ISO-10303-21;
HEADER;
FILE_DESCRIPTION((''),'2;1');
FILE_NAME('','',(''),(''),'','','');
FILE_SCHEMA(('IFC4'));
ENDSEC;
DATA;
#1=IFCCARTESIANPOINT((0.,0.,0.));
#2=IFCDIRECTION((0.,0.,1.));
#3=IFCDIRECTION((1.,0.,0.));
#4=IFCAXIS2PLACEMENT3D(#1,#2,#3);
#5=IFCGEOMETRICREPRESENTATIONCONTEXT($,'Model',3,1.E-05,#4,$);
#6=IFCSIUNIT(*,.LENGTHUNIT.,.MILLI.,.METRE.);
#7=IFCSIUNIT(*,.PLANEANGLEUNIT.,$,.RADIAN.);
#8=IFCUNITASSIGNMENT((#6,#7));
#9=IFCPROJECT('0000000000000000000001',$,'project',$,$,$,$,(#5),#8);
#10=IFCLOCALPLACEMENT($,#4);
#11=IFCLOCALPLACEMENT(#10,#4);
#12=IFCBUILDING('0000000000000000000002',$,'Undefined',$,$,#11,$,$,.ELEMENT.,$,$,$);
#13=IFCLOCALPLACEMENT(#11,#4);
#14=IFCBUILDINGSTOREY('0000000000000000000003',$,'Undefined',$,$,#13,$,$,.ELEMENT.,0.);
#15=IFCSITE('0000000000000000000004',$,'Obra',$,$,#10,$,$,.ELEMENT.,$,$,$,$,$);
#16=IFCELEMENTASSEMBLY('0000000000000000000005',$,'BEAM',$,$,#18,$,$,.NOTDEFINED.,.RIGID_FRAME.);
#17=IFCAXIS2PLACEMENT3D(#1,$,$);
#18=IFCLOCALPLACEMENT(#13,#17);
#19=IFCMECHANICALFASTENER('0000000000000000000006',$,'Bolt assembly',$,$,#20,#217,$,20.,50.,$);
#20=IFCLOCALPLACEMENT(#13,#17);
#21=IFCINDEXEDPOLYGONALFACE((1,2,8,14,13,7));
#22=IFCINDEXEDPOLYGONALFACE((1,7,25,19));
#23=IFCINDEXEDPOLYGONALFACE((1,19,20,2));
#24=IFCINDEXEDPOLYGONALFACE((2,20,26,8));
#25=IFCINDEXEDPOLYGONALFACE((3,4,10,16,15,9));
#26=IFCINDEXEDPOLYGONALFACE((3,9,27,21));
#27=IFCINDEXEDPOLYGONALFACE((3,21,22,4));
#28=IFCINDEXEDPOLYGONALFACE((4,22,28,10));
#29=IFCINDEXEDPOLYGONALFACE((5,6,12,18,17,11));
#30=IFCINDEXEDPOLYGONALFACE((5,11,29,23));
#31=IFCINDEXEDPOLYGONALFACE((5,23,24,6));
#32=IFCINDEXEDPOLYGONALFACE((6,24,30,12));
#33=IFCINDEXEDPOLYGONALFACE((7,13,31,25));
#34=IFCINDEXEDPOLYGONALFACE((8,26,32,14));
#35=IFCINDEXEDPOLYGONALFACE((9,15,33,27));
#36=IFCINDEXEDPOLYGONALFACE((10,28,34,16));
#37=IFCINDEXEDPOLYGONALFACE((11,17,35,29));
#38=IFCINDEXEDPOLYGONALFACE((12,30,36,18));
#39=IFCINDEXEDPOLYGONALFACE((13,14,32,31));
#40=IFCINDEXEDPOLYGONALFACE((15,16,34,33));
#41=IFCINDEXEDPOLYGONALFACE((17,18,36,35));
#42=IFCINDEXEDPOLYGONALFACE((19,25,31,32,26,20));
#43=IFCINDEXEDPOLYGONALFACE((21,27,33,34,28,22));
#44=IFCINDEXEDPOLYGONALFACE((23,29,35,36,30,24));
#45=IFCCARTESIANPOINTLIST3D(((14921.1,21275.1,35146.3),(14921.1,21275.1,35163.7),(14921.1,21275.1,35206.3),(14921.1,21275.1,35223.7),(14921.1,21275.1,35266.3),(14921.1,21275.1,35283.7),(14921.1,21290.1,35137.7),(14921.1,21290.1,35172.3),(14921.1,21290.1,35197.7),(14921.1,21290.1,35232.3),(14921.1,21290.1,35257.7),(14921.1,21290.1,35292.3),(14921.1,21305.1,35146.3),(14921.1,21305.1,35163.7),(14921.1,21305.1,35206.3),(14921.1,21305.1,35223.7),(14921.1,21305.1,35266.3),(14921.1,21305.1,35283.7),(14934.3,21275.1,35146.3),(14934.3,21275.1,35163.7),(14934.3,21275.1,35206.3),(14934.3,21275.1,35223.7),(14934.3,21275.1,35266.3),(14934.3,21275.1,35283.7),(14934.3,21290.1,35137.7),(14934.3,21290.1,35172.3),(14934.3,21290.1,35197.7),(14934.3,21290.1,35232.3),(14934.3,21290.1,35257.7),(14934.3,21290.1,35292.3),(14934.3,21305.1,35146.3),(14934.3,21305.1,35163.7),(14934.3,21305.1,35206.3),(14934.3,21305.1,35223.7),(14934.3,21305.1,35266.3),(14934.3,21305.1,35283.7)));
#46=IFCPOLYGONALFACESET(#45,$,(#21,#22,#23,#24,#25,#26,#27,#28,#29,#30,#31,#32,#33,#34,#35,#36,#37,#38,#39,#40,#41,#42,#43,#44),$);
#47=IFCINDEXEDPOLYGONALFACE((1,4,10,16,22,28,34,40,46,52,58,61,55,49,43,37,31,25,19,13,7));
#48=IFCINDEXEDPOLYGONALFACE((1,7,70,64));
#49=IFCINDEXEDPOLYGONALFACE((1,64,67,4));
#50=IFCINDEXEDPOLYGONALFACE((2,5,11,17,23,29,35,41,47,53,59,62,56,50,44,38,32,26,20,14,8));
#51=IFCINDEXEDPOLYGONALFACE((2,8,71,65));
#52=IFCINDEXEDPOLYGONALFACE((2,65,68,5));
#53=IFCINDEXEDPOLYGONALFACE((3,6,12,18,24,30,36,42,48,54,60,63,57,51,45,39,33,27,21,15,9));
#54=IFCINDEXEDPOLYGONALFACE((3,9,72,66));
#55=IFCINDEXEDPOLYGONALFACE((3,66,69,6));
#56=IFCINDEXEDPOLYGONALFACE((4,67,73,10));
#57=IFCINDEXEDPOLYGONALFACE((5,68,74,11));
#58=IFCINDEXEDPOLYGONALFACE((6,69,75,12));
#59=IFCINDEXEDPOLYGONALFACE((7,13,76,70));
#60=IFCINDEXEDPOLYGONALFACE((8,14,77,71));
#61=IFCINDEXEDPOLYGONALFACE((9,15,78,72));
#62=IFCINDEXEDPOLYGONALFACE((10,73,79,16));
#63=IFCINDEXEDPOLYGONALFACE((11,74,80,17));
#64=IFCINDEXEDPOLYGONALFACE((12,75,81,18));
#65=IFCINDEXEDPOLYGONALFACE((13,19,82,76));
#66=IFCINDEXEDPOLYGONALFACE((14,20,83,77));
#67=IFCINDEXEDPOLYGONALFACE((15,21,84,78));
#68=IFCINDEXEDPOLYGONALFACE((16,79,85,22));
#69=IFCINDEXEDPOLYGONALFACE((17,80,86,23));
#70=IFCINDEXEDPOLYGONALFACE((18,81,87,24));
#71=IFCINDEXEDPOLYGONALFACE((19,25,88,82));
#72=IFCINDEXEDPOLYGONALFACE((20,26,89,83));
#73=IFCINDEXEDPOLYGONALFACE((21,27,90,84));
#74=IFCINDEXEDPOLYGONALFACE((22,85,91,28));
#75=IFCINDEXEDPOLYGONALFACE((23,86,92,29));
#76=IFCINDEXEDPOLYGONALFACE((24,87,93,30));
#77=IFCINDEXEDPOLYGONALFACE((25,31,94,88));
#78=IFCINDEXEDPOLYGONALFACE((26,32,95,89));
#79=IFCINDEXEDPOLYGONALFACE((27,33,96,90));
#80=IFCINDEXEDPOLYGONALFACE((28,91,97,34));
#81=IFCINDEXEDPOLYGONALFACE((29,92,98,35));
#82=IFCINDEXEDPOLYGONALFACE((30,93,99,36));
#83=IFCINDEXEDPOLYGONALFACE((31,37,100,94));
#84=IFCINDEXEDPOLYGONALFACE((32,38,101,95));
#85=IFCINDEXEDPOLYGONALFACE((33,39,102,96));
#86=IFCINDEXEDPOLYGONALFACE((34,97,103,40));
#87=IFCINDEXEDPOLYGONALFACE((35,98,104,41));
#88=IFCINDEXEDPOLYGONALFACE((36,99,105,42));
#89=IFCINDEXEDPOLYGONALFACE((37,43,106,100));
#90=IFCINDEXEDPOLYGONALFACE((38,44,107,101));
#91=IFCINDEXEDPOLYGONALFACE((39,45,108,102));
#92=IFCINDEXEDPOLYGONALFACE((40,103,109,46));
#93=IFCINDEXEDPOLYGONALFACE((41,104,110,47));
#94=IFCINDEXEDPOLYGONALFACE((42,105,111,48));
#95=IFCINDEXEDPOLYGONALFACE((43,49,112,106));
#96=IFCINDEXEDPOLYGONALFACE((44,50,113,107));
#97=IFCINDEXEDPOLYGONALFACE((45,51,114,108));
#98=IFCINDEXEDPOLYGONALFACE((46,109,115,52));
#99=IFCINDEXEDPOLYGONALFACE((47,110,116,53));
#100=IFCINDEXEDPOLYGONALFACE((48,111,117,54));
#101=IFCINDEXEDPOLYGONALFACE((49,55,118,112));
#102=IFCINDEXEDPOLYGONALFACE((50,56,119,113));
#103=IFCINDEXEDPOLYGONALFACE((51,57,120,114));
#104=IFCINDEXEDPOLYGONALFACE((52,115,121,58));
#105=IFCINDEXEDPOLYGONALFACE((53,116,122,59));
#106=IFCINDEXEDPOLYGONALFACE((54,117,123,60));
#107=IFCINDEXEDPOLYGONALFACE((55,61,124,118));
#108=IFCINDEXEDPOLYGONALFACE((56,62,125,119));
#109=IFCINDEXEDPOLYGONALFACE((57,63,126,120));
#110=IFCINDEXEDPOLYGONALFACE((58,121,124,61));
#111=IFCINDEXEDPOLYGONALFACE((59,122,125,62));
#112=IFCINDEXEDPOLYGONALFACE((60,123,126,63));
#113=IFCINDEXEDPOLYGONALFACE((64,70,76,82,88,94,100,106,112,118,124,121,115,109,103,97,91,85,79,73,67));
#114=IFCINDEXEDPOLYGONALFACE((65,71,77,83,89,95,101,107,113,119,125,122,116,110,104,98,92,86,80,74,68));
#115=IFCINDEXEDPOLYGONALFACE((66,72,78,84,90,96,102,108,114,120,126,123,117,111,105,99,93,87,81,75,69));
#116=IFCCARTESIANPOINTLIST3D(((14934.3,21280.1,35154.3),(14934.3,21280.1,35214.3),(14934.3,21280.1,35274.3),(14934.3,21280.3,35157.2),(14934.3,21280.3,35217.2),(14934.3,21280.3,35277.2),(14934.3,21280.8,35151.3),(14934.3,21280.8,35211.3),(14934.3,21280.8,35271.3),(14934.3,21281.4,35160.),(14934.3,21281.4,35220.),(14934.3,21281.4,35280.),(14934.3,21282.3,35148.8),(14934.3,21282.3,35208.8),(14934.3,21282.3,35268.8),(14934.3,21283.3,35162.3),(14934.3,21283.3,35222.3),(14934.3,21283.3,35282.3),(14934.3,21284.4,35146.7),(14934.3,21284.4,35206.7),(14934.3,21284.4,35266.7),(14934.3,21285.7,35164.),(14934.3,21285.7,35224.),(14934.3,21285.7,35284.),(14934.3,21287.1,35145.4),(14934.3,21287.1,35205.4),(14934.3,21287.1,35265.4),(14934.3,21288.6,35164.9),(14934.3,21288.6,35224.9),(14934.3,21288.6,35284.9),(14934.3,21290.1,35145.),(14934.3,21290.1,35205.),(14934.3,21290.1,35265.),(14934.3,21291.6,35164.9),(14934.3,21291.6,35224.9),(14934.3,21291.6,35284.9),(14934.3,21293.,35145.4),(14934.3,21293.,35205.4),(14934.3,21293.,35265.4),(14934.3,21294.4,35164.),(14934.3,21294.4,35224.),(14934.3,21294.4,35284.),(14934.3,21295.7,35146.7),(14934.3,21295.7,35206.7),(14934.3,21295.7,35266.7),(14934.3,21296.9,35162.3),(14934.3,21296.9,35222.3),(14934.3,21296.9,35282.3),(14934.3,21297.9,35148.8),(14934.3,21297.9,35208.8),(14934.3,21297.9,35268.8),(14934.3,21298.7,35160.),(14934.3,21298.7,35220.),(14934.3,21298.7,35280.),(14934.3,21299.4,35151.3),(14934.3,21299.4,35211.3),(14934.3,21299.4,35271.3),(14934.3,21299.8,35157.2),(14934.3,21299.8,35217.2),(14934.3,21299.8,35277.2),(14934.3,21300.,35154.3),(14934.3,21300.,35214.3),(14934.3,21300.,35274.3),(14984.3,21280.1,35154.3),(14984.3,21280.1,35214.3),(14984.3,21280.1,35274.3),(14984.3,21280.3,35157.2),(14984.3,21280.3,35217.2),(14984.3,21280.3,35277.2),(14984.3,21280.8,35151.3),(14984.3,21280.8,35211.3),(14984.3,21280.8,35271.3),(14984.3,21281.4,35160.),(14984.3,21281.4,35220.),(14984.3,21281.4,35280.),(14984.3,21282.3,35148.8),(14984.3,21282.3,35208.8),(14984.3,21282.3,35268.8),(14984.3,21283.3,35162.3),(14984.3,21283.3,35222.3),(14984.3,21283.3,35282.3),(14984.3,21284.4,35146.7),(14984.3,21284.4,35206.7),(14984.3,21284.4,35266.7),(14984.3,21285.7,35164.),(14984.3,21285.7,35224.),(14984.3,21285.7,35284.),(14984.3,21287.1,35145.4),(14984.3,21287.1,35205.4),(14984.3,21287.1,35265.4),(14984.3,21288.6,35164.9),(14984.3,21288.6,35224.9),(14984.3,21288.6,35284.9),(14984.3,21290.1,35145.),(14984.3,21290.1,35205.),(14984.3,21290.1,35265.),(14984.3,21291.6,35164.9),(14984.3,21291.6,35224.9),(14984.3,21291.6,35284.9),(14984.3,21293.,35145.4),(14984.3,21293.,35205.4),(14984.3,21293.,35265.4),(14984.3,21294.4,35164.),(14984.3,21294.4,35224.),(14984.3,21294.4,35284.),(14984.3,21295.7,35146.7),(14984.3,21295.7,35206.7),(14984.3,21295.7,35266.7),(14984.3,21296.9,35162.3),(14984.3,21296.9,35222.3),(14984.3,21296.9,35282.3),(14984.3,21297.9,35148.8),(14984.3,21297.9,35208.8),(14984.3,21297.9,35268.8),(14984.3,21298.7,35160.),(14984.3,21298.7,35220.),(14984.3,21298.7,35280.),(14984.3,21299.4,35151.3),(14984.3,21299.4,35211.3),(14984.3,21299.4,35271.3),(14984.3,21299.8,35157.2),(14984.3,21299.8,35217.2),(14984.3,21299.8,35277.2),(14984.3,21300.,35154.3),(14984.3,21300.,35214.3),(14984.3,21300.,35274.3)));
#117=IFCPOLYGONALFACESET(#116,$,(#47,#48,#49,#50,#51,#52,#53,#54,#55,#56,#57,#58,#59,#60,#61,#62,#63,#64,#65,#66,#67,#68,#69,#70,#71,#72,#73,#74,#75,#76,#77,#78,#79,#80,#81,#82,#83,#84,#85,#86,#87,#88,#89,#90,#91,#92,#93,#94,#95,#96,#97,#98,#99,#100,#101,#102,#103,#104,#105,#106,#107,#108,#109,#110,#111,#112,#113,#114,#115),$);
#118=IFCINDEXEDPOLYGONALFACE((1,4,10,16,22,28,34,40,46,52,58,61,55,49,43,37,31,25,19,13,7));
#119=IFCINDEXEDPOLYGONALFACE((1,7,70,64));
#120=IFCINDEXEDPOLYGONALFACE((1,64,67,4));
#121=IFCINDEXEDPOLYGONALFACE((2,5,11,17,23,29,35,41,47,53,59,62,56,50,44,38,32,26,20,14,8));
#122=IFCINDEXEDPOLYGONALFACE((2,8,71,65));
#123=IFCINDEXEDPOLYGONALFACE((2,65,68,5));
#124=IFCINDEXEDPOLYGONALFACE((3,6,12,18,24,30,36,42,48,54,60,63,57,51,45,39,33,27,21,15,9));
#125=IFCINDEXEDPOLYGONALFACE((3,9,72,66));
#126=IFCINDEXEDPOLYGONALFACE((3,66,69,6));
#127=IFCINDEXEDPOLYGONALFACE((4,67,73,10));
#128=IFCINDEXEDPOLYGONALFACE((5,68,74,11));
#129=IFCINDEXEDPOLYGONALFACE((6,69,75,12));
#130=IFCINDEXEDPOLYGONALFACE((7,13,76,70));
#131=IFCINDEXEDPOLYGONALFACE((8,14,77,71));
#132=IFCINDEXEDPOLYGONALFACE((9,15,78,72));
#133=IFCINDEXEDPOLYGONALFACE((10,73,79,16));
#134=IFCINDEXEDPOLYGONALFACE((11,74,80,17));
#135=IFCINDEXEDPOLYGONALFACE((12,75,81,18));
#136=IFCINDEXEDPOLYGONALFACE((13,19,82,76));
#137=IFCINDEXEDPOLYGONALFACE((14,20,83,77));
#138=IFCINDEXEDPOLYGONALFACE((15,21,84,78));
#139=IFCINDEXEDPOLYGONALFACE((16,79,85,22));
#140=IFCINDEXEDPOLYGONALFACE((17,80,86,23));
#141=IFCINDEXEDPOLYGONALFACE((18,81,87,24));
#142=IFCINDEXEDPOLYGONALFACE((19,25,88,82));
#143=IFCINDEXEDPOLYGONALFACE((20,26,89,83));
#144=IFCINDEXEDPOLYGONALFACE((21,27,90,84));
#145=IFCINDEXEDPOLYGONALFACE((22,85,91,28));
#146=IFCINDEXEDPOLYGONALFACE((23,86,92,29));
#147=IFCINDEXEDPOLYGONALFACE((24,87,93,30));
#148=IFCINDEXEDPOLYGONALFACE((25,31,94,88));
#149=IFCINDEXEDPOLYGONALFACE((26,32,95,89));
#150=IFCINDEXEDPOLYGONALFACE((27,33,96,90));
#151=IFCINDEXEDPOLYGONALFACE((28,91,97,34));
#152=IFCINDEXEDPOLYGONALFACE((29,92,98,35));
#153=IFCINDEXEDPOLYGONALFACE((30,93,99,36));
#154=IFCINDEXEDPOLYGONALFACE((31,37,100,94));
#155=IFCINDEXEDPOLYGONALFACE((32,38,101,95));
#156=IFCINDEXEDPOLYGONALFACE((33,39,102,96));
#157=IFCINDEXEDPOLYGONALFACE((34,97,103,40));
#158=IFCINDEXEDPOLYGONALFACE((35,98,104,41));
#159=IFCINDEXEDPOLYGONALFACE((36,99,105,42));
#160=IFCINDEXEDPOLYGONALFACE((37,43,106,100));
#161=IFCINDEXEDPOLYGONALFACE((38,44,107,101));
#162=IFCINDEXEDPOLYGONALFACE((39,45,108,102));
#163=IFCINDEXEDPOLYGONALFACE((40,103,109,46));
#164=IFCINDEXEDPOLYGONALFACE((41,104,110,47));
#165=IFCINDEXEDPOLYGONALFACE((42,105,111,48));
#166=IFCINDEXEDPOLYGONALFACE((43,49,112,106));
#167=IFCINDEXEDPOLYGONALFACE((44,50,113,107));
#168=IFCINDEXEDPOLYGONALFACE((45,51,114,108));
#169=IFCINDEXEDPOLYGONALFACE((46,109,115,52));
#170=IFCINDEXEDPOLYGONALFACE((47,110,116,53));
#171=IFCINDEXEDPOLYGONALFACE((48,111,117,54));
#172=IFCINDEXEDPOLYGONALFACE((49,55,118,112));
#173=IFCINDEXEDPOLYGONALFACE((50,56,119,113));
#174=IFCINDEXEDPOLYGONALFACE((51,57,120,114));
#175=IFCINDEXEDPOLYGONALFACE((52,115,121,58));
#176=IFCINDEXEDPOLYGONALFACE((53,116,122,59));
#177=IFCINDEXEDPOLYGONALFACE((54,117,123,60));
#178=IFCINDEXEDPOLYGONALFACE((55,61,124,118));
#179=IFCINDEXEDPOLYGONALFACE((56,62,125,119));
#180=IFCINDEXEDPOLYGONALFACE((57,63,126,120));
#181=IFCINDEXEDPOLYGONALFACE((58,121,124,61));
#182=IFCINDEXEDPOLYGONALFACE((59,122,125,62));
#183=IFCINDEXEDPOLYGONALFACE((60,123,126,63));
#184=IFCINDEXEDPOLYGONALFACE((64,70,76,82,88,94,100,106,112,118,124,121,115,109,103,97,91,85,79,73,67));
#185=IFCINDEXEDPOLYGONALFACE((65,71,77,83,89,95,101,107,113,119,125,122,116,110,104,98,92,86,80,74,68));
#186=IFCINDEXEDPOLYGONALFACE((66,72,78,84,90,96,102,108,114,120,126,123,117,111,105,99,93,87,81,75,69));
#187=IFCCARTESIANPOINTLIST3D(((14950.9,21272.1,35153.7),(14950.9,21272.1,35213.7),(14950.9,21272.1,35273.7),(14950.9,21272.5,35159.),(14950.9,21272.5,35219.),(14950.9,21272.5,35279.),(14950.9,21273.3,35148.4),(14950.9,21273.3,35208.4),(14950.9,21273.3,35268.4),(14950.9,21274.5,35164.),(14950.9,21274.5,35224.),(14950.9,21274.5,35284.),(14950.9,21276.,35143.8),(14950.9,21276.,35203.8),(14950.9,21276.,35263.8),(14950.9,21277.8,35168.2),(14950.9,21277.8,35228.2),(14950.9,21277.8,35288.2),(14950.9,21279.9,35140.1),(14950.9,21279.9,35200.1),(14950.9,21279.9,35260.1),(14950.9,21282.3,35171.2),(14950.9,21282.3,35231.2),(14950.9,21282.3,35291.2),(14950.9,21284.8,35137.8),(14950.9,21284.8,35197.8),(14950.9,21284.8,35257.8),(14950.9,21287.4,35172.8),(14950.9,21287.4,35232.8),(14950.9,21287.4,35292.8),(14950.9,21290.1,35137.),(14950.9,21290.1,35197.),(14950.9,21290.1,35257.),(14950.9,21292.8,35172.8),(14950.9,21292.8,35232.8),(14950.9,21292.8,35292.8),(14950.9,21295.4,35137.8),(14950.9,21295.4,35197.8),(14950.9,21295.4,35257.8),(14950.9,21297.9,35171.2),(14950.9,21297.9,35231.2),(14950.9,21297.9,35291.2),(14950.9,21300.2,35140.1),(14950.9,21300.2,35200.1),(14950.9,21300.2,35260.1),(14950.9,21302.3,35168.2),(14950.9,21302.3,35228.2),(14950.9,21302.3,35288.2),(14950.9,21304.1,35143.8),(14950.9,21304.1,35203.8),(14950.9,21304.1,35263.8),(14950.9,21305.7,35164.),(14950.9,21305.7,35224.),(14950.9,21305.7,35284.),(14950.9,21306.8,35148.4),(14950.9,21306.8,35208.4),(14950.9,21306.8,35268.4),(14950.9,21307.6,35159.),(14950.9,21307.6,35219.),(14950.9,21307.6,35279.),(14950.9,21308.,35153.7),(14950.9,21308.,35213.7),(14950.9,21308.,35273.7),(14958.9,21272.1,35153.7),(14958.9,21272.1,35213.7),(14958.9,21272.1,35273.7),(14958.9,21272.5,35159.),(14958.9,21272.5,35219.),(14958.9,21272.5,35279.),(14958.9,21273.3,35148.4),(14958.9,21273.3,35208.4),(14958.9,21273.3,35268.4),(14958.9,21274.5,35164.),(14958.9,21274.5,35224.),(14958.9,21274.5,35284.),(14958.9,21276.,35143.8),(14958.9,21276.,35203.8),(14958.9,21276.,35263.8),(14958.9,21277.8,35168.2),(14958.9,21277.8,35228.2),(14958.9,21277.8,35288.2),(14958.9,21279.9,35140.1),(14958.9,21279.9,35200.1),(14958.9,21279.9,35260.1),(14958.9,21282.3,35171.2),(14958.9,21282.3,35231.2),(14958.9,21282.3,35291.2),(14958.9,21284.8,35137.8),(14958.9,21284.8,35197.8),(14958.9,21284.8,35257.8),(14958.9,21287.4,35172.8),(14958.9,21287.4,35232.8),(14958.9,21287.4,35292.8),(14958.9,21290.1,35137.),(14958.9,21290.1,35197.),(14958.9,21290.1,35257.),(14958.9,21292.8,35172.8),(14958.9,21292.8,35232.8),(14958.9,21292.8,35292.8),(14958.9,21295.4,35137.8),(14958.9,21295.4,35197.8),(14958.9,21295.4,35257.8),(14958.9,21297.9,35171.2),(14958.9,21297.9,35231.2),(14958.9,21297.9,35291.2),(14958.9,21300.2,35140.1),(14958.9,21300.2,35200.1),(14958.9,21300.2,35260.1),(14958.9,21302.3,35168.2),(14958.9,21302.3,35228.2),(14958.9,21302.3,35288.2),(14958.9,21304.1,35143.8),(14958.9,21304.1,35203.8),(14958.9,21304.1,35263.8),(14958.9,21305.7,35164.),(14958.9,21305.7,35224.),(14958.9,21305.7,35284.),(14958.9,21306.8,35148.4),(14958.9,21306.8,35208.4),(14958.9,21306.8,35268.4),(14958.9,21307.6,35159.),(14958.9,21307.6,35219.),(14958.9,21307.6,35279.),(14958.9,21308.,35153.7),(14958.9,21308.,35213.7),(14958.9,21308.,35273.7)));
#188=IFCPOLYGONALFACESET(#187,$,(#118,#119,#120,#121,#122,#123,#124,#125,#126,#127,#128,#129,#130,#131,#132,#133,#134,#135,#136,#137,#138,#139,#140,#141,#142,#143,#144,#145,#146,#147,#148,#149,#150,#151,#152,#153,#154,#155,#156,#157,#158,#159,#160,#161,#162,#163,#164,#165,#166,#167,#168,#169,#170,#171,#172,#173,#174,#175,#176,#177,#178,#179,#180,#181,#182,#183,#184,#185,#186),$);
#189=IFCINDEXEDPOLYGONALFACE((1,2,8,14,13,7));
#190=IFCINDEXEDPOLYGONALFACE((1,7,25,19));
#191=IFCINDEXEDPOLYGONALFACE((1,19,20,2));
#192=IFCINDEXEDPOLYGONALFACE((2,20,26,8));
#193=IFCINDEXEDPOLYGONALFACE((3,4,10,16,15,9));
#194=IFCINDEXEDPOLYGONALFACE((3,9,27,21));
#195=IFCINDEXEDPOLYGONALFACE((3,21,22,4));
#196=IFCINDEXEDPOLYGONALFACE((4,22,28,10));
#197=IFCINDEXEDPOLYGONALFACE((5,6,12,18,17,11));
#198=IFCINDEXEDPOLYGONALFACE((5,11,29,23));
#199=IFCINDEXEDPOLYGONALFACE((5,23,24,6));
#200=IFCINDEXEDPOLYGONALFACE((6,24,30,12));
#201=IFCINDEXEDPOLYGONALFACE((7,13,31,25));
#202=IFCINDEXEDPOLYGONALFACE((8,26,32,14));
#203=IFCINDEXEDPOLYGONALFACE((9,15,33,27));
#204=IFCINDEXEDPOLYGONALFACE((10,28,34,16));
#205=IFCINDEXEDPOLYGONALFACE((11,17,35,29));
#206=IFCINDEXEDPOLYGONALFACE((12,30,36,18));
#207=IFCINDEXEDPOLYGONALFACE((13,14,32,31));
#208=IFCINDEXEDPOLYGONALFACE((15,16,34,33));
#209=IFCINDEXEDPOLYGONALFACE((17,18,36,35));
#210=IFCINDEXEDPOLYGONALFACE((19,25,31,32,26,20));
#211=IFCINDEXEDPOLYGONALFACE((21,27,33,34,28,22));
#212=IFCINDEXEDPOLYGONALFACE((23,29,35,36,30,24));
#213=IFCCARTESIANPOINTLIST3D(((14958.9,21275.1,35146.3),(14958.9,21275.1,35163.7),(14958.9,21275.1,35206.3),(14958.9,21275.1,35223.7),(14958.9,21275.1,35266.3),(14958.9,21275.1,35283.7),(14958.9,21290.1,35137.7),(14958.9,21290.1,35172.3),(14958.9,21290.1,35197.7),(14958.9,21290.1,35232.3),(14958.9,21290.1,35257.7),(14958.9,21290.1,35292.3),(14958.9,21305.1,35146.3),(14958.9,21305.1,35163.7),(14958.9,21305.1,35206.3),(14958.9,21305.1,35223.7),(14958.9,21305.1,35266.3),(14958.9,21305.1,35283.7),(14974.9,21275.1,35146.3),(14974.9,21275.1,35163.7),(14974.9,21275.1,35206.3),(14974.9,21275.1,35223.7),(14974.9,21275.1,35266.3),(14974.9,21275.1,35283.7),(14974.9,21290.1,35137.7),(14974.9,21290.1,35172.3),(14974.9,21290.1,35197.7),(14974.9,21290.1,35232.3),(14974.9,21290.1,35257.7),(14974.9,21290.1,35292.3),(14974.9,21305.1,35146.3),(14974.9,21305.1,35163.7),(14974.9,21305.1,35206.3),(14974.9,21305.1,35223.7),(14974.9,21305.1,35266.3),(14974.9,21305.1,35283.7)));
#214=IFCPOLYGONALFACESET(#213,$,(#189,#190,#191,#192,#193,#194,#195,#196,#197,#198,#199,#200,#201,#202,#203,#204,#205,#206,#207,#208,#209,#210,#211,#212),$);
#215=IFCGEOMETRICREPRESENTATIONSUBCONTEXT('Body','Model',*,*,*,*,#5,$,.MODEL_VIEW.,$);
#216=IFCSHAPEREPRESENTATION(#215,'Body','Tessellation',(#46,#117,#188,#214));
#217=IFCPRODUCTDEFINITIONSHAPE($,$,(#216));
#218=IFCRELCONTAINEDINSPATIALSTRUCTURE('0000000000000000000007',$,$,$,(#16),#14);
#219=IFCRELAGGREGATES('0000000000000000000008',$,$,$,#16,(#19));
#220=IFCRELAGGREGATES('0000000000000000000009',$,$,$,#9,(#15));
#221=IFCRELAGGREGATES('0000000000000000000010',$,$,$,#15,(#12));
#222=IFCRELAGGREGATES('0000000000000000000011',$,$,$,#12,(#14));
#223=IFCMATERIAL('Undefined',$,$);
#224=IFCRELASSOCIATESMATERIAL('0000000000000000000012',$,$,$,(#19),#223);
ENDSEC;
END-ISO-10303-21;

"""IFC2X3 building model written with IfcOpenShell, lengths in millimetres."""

from ifc_helpers import new_model, si_unit, frame, origin_with_axes, origin_2d_with_axis, place, context, subcontext, project, spatial, polyline, circle, outline, extrude, source, transform, mapped, material, element, aggregate, save


model = new_model("IFC2X3")

# Units and contexts
model_context = context("Model", 3, precision=1e-05, world=origin_with_axes())
body_context = subcontext(model_context, "Body", "Model", "MODEL_VIEW")
ifc_project = project(units=[si_unit("LENGTHUNIT", "METRE", prefix="MILLI"), si_unit("PLANEANGLEUNIT", "RADIAN")], contexts=[model_context])

# Site, building, storey
site_placement = place(None, origin_with_axes())
site = spatial("IfcSite", under=ifc_project, at=site_placement, Name="Obra", CompositionType="ELEMENT")
building_placement = place(site_placement, origin_with_axes())
building = spatial("IfcBuilding", under=site, at=building_placement, Name="Undefined", CompositionType="ELEMENT")
storey_placement = place(building_placement, origin_with_axes())
storey = spatial("IfcBuildingStorey", under=building, at=storey_placement, Name="Undefined", CompositionType="ELEMENT", Elevation=0.0)

# Shared definitions
ifc_material_1 = material(Name="Undefined")

# Element assembly, mechanical fastener
assembly_1_placement = place(storey_placement, origin_with_axes())
assembly_1 = element("IfcElementAssembly", 1, at=assembly_1_placement, inside=storey, Name="BEAM", AssemblyPlace="NOTDEFINED", PredefinedType="RIGID_FRAME")
shared_shape_1 = source(origin_with_axes(), body_context, "Body", "SweptSolid", [
    extrude(outline(polyline([(17.3, 0.0), (8.7, 15.0), (-8.7, 15.0), (-17.3, 0.0), (-8.7, -15.0), (8.7, -15.0), (17.3, 0.0)])), frame((0.0, -26.5, 0.0), z_axis=(0.0, 1.0, 0.0), x_axis=(1.0, 0.0, 0.0)), (0.0, 0.0, 1.0), 13.2),
    extrude(circle(Radius=10.0, at=origin_2d_with_axis()), frame((0.0, -13.3, 0.0), z_axis=(0.0, 1.0, 0.0), x_axis=(1.0, 0.0, 0.0)), (0.0, 0.0, 1.0), 50.0),
    extrude(circle(Radius=18.0, at=origin_2d_with_axis()), frame((0.0, 3.3, 0.0), z_axis=(0.0, 1.0, 0.0), x_axis=(1.0, 0.0, 0.0)), (0.0, 0.0, 1.0), 8.0),
    extrude(outline(polyline([(17.3, 0.0), (8.7, 15.0), (-8.7, 15.0), (-17.3, 0.0), (-8.7, -15.0), (8.7, -15.0), (17.3, 0.0)])), frame((0.0, 11.3, 0.0), z_axis=(0.0, 1.0, 0.0), x_axis=(1.0, 0.0, 0.0)), (0.0, 0.0, 1.0), 16.0),
])
mechanical_fastener_1_placement = place(assembly_1_placement, frame((14947.6, 21340.1, 35315.0), z_axis=(0.000013, -1.0, 0.0), x_axis=(0.0, 0.0, -1.0)))
mechanical_fastener_1 = element("IfcMechanicalFastener", 2, at=mechanical_fastener_1_placement, material=ifc_material_1, Name="Bolt assembly", NominalDiameter=20.0, NominalLength=50.0, context=body_context, shape_type="MappedRepresentation", body=[
    mapped(shared_shape_1, transform((40.0, 0.0, 50.0))),
    mapped(shared_shape_1, transform((100.0, 0.0, 50.0))),
    mapped(shared_shape_1, transform((160.0, 0.0, 50.0))),
])
aggregate(assembly_1, [mechanical_fastener_1])

save(model, "model.ifc")
